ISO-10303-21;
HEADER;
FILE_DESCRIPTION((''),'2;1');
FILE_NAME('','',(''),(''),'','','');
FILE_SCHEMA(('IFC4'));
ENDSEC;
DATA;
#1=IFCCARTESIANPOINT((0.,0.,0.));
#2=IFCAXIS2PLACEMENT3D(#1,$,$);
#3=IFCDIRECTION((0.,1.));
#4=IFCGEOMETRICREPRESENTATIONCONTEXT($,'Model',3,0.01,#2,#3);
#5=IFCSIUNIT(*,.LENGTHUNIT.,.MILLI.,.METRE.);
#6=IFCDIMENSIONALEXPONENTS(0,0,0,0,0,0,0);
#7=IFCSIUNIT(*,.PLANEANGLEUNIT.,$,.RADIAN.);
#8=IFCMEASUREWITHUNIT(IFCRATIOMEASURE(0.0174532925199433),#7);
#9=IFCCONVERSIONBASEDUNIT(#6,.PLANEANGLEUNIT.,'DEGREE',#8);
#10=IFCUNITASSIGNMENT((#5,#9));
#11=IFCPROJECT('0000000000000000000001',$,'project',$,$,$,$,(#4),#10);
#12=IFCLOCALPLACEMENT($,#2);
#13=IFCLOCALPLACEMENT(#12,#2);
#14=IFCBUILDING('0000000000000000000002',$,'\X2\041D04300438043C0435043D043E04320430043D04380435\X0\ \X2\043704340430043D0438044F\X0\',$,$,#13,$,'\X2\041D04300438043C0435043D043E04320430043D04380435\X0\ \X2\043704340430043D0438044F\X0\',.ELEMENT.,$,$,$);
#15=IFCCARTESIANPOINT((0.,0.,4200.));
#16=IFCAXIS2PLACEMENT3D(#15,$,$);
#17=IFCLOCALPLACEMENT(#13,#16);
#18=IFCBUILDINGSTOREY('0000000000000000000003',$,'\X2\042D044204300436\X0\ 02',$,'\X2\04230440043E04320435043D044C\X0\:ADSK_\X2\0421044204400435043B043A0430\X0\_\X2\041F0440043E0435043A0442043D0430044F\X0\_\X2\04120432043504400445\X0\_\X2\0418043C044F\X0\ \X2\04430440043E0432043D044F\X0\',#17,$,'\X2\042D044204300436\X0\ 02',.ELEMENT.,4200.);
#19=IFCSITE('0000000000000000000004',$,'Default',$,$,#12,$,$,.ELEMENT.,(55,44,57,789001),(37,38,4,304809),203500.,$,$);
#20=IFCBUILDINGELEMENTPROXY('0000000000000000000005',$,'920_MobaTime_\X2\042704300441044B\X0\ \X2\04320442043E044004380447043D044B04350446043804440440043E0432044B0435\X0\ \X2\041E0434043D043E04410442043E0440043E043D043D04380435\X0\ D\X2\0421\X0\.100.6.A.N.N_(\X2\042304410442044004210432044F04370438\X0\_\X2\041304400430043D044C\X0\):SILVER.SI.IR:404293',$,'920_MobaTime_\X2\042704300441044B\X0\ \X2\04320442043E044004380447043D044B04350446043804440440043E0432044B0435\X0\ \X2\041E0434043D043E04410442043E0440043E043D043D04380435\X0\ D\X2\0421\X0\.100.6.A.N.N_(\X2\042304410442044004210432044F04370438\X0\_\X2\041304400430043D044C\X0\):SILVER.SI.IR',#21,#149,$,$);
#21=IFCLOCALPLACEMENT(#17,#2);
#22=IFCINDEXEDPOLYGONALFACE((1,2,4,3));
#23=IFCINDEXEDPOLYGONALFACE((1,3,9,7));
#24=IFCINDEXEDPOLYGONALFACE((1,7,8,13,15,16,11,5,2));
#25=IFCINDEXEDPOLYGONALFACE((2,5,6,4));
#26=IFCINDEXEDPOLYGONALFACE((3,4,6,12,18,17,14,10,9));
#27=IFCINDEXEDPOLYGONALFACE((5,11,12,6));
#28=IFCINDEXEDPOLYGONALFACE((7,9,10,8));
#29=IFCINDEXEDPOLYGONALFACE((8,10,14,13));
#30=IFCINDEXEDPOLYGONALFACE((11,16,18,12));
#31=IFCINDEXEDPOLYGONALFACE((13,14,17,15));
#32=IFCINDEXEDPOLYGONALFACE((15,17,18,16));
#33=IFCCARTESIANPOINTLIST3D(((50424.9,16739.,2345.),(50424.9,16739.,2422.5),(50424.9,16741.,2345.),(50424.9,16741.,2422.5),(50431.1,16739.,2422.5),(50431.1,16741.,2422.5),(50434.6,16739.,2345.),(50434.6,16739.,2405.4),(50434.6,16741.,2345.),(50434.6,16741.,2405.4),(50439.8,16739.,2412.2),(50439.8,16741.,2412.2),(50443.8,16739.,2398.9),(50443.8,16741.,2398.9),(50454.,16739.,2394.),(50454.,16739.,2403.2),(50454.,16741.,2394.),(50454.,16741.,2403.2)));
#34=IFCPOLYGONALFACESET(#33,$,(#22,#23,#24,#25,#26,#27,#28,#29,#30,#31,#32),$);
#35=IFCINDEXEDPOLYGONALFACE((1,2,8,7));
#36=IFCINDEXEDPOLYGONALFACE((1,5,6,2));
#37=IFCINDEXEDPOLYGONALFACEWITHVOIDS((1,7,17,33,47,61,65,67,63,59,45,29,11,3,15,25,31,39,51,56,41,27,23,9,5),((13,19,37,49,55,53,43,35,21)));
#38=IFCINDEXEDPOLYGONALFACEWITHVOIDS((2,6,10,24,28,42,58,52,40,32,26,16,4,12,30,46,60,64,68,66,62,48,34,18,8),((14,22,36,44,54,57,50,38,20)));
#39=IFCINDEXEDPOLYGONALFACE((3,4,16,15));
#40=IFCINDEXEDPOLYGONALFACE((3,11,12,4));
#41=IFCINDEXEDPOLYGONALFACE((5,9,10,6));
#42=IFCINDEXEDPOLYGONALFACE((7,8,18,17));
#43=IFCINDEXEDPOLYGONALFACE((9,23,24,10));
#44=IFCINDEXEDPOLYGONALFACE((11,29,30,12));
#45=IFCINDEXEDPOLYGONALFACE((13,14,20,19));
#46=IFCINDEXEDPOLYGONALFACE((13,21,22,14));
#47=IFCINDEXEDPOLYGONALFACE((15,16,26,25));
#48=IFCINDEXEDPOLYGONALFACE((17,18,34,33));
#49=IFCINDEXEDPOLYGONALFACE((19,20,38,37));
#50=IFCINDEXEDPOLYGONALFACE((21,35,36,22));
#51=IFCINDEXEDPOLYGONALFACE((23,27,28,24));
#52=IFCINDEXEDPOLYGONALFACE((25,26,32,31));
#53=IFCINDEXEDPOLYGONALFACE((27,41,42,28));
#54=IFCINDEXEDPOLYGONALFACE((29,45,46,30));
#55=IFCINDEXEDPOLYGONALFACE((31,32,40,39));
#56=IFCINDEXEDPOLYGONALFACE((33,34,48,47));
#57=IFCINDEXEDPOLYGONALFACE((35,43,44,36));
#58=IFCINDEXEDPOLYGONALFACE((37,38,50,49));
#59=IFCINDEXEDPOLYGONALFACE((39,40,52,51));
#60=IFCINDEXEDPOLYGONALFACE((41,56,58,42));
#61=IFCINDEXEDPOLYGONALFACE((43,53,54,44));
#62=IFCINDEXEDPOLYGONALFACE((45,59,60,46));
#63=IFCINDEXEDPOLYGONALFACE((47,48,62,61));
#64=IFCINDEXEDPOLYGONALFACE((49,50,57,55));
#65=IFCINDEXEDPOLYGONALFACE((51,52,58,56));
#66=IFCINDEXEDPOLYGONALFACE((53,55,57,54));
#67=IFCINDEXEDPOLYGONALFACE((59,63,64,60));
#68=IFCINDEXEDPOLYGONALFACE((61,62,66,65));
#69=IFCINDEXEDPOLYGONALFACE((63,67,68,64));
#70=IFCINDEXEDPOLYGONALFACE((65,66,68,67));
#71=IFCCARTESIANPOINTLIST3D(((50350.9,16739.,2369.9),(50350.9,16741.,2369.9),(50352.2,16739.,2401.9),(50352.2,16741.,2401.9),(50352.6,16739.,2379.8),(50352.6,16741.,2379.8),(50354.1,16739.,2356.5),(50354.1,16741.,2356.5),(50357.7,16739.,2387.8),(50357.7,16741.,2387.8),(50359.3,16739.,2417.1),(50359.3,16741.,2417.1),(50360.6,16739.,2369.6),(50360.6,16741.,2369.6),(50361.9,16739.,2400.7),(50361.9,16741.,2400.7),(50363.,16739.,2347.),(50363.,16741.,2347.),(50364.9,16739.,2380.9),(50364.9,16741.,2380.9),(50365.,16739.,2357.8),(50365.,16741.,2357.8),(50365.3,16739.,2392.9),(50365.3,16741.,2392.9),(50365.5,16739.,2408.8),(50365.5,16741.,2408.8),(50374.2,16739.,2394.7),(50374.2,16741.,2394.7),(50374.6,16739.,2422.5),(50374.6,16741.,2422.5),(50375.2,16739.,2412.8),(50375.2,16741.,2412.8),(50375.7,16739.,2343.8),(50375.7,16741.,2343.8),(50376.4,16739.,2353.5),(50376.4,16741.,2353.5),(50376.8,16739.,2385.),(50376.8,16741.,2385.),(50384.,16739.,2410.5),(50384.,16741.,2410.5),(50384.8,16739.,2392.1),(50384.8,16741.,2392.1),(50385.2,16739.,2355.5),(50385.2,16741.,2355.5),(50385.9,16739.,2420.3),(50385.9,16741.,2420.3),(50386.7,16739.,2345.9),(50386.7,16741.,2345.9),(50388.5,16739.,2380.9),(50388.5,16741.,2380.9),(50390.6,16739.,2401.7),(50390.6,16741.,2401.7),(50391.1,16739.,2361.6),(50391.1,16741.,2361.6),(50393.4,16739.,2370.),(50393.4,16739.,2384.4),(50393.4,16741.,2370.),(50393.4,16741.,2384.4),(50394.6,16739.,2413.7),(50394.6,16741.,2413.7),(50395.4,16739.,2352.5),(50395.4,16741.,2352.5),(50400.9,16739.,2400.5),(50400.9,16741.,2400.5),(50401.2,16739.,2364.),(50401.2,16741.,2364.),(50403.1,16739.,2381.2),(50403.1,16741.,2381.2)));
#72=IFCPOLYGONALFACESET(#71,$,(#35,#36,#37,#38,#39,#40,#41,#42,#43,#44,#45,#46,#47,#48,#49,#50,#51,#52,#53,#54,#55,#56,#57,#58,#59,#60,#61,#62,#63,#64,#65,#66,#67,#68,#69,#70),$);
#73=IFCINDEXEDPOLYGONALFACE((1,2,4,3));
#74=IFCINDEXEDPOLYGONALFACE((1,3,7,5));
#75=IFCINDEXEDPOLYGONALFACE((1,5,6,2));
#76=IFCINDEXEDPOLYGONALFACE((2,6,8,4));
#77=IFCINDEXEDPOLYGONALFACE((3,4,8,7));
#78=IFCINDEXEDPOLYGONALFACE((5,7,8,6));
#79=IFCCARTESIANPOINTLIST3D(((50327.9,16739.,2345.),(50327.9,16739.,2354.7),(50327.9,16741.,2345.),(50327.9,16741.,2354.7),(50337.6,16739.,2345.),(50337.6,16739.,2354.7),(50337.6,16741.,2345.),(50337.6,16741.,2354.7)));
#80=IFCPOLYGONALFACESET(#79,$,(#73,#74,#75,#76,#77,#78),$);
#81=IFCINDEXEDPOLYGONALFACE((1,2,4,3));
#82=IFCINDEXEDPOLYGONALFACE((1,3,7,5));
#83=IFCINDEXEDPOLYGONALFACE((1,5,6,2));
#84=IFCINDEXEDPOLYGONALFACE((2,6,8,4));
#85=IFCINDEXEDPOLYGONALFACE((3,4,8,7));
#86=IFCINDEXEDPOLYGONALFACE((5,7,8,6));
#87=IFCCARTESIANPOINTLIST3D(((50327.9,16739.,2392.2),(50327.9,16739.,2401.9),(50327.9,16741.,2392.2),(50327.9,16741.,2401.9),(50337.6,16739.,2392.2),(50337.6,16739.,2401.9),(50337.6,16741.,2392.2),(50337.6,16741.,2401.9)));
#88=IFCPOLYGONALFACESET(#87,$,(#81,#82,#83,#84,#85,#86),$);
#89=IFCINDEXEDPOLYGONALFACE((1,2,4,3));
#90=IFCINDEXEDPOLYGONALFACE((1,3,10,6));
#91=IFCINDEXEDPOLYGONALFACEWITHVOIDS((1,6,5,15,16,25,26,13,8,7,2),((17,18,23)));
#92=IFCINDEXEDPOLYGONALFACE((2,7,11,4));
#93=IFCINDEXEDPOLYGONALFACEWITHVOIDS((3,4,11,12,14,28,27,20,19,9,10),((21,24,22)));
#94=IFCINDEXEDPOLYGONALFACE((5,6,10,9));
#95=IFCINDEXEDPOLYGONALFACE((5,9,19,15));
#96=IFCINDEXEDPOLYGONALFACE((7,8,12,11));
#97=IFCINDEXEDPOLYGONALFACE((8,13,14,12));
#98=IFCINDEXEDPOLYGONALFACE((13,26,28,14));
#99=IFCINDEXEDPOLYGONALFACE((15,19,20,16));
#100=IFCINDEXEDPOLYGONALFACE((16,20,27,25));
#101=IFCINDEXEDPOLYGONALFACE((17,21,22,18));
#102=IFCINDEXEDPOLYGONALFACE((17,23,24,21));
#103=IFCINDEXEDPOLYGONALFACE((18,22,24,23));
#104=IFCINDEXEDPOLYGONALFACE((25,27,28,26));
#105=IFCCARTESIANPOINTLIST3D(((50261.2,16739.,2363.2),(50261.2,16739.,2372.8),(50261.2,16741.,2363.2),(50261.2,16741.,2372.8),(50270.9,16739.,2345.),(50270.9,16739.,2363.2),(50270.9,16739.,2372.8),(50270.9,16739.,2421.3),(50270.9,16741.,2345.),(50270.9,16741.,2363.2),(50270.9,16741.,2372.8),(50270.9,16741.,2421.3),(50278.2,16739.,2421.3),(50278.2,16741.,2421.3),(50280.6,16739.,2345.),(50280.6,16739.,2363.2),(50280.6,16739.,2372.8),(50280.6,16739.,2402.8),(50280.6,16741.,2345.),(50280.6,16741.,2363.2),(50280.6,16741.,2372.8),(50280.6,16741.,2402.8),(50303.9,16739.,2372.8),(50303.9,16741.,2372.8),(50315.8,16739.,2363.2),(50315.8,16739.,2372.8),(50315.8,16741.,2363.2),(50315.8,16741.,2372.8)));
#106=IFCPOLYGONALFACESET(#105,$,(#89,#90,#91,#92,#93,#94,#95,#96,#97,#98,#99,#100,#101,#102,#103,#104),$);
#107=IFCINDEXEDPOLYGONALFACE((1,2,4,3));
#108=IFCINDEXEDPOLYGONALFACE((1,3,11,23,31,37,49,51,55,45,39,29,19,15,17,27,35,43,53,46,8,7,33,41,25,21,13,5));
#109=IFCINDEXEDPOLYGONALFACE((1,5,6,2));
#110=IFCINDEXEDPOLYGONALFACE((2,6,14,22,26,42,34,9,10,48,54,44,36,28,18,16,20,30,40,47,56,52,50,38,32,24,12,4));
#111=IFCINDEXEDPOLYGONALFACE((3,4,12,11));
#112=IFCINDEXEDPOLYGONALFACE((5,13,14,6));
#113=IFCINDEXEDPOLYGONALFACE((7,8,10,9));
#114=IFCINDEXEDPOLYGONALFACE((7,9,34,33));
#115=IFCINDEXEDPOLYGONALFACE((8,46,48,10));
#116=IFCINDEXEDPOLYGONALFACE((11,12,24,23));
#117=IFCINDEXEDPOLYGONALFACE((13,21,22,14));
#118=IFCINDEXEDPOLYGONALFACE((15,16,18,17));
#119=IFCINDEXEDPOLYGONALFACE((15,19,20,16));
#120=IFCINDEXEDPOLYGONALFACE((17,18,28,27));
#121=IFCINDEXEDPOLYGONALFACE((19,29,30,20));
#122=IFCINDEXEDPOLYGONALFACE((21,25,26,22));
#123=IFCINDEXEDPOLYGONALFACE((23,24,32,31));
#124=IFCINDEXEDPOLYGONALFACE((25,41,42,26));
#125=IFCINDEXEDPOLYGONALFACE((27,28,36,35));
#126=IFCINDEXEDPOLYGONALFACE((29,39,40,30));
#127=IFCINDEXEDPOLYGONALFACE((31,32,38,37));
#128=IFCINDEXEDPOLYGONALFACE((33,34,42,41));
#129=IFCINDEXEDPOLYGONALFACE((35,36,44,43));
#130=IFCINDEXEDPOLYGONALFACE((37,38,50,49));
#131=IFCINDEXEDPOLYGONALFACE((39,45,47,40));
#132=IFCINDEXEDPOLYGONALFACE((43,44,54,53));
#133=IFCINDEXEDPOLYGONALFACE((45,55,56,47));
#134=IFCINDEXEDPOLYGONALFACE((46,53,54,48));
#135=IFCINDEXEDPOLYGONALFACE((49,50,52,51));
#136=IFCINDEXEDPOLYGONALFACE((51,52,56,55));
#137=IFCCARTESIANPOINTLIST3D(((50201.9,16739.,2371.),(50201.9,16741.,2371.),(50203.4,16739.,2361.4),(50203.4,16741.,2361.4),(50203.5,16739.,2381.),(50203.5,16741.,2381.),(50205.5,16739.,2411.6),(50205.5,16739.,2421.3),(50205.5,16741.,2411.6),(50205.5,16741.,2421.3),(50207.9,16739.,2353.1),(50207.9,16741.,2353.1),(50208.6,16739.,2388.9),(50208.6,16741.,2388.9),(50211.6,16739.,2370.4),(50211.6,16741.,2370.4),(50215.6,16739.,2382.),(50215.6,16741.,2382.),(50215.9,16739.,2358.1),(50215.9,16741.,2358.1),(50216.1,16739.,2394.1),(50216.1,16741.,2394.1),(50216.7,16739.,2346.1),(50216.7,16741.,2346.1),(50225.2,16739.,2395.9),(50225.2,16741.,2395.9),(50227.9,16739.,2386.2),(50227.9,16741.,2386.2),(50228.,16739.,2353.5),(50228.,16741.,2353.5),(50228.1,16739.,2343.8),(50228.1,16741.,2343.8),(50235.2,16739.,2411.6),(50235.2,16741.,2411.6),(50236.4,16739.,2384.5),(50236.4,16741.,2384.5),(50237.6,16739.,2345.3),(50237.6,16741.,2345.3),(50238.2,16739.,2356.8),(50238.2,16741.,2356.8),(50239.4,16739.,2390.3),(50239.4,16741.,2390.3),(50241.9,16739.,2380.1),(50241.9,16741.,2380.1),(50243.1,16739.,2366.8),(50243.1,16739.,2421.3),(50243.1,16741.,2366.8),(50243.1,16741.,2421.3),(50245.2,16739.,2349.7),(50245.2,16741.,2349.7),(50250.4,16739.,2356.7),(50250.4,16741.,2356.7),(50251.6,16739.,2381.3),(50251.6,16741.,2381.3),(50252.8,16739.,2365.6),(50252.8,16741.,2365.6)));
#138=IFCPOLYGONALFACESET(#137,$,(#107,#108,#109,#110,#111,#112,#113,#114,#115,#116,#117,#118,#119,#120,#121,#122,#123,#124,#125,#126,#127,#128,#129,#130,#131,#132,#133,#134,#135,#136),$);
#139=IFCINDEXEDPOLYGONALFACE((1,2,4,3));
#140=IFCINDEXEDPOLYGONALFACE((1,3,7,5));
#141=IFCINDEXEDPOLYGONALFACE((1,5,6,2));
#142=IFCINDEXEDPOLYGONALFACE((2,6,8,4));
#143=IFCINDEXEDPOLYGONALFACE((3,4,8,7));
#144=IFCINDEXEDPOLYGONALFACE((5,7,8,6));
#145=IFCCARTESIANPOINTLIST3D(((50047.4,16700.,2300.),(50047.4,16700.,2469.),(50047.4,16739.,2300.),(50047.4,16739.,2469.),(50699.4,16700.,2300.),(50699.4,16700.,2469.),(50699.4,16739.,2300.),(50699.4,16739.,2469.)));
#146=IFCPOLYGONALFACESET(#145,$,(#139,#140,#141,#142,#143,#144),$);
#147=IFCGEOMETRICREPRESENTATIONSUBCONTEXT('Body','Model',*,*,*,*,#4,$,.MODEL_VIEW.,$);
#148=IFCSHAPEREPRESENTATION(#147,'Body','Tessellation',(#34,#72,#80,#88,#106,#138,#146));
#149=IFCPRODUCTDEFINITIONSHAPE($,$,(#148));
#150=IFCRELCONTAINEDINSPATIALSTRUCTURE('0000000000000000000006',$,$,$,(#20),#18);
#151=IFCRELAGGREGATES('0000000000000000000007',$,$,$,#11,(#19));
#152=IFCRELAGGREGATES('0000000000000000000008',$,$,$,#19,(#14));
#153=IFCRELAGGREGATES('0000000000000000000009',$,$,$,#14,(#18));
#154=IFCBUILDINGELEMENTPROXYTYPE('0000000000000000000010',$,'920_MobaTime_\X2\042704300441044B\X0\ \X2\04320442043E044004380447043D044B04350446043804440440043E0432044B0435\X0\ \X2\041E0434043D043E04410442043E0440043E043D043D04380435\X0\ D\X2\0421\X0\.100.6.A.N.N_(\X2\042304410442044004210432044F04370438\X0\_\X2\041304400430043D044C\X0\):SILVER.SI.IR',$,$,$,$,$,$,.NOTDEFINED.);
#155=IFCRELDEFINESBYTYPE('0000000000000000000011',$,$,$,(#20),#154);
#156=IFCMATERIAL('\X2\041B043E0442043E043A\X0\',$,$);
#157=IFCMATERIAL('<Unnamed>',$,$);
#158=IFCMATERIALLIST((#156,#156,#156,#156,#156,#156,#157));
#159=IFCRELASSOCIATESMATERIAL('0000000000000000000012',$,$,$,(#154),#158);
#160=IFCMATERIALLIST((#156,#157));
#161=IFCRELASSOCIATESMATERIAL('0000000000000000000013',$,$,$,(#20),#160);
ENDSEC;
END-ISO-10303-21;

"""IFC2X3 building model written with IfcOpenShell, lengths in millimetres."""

from ifc_helpers import new_model, entity, si_unit, converted_unit, direction, frame, origin, origin_2d_with_axis, place, context, subcontext, project, spatial, polyline, rectangle, outline, extrude, source, transform, mapped, material, material_list, type_object, type_shapes, element, save


model = new_model("IFC2X3")

# Units and contexts
model_context = context("Model", 3, precision=0.01, world=origin(), true_north=direction((0.0, 1.0)))
body_context = subcontext(model_context, "Body", "Model", "MODEL_VIEW")
ifc_project = project(units=[si_unit("LENGTHUNIT", "METRE", prefix="MILLI"), converted_unit("PLANEANGLEUNIT", "DEGREE", entity("IfcRatioMeasure", 0.0174532925199433), si_unit("PLANEANGLEUNIT", "RADIAN"), dimensions=[0, 0, 0, 0, 0, 0, 0])], contexts=[model_context])

# Site, building, storey
site_placement = place(None, frame((0.0, 0.0, 0.0)))
site = spatial("IfcSite", under=ifc_project, at=site_placement, Name="Default", CompositionType="ELEMENT", RefLatitude=(55, 44, 57, 789001), RefLongitude=(37, 38, 4, 304809), RefElevation=203500.0)
building_placement = place(site_placement, origin())
building = spatial("IfcBuilding", under=site, at=building_placement, Name="Наименование здания", LongName="Наименование здания", CompositionType="ELEMENT")
storey_placement = place(building_placement, frame((0.0, 0.0, 4200.0)))
storey = spatial("IfcBuildingStorey", under=building, at=storey_placement, Name="Этаж 02", ObjectType="Уровень:ADSK_Стрелка_Проектная_Вверх_Имя уровня", LongName="Этаж 02", CompositionType="ELEMENT", Elevation=4200.0)

# Building element proxy
ifc_material_1 = material(Name="Лоток")
ifc_material_2 = material(Name="<Unnamed>")
ifc_material_list_1 = material_list([ifc_material_1, ifc_material_1, ifc_material_1, ifc_material_1, ifc_material_1, ifc_material_1, ifc_material_2])
building_element_proxy_type_1 = type_object("IfcBuildingElementProxyType", Name="920_MobaTime_Часы вторичныецифровые Односторонние DС.100.6.A.N.N_(УстрСвязи_Грань):SILVER.SI.IR", PredefinedType="NOTDEFINED", material=ifc_material_list_1)
shared_shape_1 = source(origin(), body_context, "Body", "SweptSolid", [
    extrude(outline(polyline([(-49.3, -13.1), (28.2, -13.1), (28.2, -6.8), (17.9, 1.8), (8.9, 16.0), (-0.3, 16.0), (4.6, 5.8), (11.1, -3.4), (-49.3, -3.4), (-49.3, -13.1)])), frame((-64.6, 9.8, 39.0), z_axis=(0.0, 0.0, 1.0), x_axis=(0.0, 1.0, 0.0)), (0.0, 0.0, 1.0), 2.0),
    extrude(outline(polyline([(2.2, -27.6), (19.0, -27.6), (30.5, -16.1), (33.3, -4.9), (31.0, 5.8), (21.8, 17.2), (5.2, 27.3), (-11.1, 33.0), (-24.0, 32.7), (-33.6, 27.6), (-40.3, 18.6), (-42.8, 5.7), (-38.0, -6.3), (-27.2, -15.0), (-17.5, -17.7), (-8.2, -16.4), (-0.3, -11.9), (5.1, -4.5), (7.3, 6.2), (4.0, 17.2), (18.5, 7.3), (23.6, -2.4), (22.0, -11.4), (14.2, -18.4), (5.3, -18.3), (2.2, -27.6)]), holes=[polyline([(-9.0, 23.3), (-1.3, 14.4), (-2.6, 2.0), (-11.4, -7.0), (-23.4, -6.1), (-32.2, 2.9), (-31.2, 15.1), (-25.6, 22.1), (-17.5, 24.9), (-9.0, 23.3)])]), frame((-2.7, 3.6, 39.0), z_axis=(0.0, 0.0, 1.0), x_axis=(-0.427649, 0.903945, 0.0)), (0.0, 0.0, 1.0), 2.0),
    extrude(rectangle(XDim=9.7, YDim=9.7, at=origin_2d_with_axis()), frame((40.6, -34.7, 39.0)), (0.0, 0.0, 1.0), 2.0),
    extrude(rectangle(XDim=9.7, YDim=9.7, at=origin_2d_with_axis()), frame((40.6, 12.6, 39.0)), (0.0, 0.0, 1.0), 2.0),
    extrude(outline(polyline([(-0.9, -28.1), (8.8, -28.1), (8.8, -9.9), (18.5, -9.9), (18.5, -0.2), (8.8, -0.2), (8.8, 48.3), (1.5, 48.3), (-36.0, -0.2), (-36.0, -9.9), (-0.9, -9.9), (-0.9, -28.1)]), holes=[polyline([(-0.9, -0.2), (-24.1, -0.2), (-0.9, 29.7), (-0.9, -0.2)])]), frame((93.6, -11.4, 39.0)), (0.0, 0.0, 1.0), 2.0),
    extrude(outline(polyline([(3.3, -28.3), (12.5, -28.3), (20.5, -25.0), (26.8, -18.8), (30.7, -10.0), (31.4, 1.6), (26.9, 11.8), (20.1, 18.4), (11.1, 22.3), (1.0, 23.3), (-7.9, 20.4), (-14.9, 14.5), (-18.9, 6.2), (-17.1, -9.0), (-36.7, 0.5), (-29.1, 29.3), (-38.5, 31.7), (-48.1, -4.6), (-11.6, -23.0), (-8.0, -14.0), (-10.8, -7.6), (-10.2, 1.1), (-3.0, 11.8), (9.2, 12.8), (20.0, 5.4), (21.3, -7.5), (15.5, -16.4), (4.6, -18.6), (3.3, -28.3)])), frame((147.1, -8.5, 39.0), z_axis=(0.0, 0.0, 1.0), x_axis=(0.256974, -0.966418, 0.0)), (0.0, 0.0, 1.0), 2.0),
    extrude(rectangle(XDim=652.0, YDim=169.0, at=origin_2d_with_axis()), frame((0.0, 0.0, 0.0), z_axis=(0.0, 0.0, 1.0), x_axis=(-1.0, 0.0, 0.0)), (0.0, 0.0, 1.0), 39.0),
])
type_shapes(building_element_proxy_type_1, [shared_shape_1])
ifc_material_list_2 = material_list([ifc_material_1, ifc_material_2])
proxy_1_placement = place(storey_placement, frame((50373.4, 16700.0, 2384.5), z_axis=(0.0, 1.0, 0.0), x_axis=(-1.0, 0.0, 0.0)))
element("IfcBuildingElementProxy", 1, at=proxy_1_placement, inside=storey, type_object=building_element_proxy_type_1, material=ifc_material_list_2, Name="920_MobaTime_Часы вторичныецифровые Односторонние DС.100.6.A.N.N_(УстрСвязи_Грань):SILVER.SI.IR:404293", ObjectType="920_MobaTime_Часы вторичныецифровые Односторонние DС.100.6.A.N.N_(УстрСвязи_Грань):SILVER.SI.IR", context=body_context, shape_type="MappedRepresentation", body=[
    mapped(shared_shape_1, transform((0.0, 0.0, 0.0), scale=1.0)),
])

save(model, "model.ifc")
